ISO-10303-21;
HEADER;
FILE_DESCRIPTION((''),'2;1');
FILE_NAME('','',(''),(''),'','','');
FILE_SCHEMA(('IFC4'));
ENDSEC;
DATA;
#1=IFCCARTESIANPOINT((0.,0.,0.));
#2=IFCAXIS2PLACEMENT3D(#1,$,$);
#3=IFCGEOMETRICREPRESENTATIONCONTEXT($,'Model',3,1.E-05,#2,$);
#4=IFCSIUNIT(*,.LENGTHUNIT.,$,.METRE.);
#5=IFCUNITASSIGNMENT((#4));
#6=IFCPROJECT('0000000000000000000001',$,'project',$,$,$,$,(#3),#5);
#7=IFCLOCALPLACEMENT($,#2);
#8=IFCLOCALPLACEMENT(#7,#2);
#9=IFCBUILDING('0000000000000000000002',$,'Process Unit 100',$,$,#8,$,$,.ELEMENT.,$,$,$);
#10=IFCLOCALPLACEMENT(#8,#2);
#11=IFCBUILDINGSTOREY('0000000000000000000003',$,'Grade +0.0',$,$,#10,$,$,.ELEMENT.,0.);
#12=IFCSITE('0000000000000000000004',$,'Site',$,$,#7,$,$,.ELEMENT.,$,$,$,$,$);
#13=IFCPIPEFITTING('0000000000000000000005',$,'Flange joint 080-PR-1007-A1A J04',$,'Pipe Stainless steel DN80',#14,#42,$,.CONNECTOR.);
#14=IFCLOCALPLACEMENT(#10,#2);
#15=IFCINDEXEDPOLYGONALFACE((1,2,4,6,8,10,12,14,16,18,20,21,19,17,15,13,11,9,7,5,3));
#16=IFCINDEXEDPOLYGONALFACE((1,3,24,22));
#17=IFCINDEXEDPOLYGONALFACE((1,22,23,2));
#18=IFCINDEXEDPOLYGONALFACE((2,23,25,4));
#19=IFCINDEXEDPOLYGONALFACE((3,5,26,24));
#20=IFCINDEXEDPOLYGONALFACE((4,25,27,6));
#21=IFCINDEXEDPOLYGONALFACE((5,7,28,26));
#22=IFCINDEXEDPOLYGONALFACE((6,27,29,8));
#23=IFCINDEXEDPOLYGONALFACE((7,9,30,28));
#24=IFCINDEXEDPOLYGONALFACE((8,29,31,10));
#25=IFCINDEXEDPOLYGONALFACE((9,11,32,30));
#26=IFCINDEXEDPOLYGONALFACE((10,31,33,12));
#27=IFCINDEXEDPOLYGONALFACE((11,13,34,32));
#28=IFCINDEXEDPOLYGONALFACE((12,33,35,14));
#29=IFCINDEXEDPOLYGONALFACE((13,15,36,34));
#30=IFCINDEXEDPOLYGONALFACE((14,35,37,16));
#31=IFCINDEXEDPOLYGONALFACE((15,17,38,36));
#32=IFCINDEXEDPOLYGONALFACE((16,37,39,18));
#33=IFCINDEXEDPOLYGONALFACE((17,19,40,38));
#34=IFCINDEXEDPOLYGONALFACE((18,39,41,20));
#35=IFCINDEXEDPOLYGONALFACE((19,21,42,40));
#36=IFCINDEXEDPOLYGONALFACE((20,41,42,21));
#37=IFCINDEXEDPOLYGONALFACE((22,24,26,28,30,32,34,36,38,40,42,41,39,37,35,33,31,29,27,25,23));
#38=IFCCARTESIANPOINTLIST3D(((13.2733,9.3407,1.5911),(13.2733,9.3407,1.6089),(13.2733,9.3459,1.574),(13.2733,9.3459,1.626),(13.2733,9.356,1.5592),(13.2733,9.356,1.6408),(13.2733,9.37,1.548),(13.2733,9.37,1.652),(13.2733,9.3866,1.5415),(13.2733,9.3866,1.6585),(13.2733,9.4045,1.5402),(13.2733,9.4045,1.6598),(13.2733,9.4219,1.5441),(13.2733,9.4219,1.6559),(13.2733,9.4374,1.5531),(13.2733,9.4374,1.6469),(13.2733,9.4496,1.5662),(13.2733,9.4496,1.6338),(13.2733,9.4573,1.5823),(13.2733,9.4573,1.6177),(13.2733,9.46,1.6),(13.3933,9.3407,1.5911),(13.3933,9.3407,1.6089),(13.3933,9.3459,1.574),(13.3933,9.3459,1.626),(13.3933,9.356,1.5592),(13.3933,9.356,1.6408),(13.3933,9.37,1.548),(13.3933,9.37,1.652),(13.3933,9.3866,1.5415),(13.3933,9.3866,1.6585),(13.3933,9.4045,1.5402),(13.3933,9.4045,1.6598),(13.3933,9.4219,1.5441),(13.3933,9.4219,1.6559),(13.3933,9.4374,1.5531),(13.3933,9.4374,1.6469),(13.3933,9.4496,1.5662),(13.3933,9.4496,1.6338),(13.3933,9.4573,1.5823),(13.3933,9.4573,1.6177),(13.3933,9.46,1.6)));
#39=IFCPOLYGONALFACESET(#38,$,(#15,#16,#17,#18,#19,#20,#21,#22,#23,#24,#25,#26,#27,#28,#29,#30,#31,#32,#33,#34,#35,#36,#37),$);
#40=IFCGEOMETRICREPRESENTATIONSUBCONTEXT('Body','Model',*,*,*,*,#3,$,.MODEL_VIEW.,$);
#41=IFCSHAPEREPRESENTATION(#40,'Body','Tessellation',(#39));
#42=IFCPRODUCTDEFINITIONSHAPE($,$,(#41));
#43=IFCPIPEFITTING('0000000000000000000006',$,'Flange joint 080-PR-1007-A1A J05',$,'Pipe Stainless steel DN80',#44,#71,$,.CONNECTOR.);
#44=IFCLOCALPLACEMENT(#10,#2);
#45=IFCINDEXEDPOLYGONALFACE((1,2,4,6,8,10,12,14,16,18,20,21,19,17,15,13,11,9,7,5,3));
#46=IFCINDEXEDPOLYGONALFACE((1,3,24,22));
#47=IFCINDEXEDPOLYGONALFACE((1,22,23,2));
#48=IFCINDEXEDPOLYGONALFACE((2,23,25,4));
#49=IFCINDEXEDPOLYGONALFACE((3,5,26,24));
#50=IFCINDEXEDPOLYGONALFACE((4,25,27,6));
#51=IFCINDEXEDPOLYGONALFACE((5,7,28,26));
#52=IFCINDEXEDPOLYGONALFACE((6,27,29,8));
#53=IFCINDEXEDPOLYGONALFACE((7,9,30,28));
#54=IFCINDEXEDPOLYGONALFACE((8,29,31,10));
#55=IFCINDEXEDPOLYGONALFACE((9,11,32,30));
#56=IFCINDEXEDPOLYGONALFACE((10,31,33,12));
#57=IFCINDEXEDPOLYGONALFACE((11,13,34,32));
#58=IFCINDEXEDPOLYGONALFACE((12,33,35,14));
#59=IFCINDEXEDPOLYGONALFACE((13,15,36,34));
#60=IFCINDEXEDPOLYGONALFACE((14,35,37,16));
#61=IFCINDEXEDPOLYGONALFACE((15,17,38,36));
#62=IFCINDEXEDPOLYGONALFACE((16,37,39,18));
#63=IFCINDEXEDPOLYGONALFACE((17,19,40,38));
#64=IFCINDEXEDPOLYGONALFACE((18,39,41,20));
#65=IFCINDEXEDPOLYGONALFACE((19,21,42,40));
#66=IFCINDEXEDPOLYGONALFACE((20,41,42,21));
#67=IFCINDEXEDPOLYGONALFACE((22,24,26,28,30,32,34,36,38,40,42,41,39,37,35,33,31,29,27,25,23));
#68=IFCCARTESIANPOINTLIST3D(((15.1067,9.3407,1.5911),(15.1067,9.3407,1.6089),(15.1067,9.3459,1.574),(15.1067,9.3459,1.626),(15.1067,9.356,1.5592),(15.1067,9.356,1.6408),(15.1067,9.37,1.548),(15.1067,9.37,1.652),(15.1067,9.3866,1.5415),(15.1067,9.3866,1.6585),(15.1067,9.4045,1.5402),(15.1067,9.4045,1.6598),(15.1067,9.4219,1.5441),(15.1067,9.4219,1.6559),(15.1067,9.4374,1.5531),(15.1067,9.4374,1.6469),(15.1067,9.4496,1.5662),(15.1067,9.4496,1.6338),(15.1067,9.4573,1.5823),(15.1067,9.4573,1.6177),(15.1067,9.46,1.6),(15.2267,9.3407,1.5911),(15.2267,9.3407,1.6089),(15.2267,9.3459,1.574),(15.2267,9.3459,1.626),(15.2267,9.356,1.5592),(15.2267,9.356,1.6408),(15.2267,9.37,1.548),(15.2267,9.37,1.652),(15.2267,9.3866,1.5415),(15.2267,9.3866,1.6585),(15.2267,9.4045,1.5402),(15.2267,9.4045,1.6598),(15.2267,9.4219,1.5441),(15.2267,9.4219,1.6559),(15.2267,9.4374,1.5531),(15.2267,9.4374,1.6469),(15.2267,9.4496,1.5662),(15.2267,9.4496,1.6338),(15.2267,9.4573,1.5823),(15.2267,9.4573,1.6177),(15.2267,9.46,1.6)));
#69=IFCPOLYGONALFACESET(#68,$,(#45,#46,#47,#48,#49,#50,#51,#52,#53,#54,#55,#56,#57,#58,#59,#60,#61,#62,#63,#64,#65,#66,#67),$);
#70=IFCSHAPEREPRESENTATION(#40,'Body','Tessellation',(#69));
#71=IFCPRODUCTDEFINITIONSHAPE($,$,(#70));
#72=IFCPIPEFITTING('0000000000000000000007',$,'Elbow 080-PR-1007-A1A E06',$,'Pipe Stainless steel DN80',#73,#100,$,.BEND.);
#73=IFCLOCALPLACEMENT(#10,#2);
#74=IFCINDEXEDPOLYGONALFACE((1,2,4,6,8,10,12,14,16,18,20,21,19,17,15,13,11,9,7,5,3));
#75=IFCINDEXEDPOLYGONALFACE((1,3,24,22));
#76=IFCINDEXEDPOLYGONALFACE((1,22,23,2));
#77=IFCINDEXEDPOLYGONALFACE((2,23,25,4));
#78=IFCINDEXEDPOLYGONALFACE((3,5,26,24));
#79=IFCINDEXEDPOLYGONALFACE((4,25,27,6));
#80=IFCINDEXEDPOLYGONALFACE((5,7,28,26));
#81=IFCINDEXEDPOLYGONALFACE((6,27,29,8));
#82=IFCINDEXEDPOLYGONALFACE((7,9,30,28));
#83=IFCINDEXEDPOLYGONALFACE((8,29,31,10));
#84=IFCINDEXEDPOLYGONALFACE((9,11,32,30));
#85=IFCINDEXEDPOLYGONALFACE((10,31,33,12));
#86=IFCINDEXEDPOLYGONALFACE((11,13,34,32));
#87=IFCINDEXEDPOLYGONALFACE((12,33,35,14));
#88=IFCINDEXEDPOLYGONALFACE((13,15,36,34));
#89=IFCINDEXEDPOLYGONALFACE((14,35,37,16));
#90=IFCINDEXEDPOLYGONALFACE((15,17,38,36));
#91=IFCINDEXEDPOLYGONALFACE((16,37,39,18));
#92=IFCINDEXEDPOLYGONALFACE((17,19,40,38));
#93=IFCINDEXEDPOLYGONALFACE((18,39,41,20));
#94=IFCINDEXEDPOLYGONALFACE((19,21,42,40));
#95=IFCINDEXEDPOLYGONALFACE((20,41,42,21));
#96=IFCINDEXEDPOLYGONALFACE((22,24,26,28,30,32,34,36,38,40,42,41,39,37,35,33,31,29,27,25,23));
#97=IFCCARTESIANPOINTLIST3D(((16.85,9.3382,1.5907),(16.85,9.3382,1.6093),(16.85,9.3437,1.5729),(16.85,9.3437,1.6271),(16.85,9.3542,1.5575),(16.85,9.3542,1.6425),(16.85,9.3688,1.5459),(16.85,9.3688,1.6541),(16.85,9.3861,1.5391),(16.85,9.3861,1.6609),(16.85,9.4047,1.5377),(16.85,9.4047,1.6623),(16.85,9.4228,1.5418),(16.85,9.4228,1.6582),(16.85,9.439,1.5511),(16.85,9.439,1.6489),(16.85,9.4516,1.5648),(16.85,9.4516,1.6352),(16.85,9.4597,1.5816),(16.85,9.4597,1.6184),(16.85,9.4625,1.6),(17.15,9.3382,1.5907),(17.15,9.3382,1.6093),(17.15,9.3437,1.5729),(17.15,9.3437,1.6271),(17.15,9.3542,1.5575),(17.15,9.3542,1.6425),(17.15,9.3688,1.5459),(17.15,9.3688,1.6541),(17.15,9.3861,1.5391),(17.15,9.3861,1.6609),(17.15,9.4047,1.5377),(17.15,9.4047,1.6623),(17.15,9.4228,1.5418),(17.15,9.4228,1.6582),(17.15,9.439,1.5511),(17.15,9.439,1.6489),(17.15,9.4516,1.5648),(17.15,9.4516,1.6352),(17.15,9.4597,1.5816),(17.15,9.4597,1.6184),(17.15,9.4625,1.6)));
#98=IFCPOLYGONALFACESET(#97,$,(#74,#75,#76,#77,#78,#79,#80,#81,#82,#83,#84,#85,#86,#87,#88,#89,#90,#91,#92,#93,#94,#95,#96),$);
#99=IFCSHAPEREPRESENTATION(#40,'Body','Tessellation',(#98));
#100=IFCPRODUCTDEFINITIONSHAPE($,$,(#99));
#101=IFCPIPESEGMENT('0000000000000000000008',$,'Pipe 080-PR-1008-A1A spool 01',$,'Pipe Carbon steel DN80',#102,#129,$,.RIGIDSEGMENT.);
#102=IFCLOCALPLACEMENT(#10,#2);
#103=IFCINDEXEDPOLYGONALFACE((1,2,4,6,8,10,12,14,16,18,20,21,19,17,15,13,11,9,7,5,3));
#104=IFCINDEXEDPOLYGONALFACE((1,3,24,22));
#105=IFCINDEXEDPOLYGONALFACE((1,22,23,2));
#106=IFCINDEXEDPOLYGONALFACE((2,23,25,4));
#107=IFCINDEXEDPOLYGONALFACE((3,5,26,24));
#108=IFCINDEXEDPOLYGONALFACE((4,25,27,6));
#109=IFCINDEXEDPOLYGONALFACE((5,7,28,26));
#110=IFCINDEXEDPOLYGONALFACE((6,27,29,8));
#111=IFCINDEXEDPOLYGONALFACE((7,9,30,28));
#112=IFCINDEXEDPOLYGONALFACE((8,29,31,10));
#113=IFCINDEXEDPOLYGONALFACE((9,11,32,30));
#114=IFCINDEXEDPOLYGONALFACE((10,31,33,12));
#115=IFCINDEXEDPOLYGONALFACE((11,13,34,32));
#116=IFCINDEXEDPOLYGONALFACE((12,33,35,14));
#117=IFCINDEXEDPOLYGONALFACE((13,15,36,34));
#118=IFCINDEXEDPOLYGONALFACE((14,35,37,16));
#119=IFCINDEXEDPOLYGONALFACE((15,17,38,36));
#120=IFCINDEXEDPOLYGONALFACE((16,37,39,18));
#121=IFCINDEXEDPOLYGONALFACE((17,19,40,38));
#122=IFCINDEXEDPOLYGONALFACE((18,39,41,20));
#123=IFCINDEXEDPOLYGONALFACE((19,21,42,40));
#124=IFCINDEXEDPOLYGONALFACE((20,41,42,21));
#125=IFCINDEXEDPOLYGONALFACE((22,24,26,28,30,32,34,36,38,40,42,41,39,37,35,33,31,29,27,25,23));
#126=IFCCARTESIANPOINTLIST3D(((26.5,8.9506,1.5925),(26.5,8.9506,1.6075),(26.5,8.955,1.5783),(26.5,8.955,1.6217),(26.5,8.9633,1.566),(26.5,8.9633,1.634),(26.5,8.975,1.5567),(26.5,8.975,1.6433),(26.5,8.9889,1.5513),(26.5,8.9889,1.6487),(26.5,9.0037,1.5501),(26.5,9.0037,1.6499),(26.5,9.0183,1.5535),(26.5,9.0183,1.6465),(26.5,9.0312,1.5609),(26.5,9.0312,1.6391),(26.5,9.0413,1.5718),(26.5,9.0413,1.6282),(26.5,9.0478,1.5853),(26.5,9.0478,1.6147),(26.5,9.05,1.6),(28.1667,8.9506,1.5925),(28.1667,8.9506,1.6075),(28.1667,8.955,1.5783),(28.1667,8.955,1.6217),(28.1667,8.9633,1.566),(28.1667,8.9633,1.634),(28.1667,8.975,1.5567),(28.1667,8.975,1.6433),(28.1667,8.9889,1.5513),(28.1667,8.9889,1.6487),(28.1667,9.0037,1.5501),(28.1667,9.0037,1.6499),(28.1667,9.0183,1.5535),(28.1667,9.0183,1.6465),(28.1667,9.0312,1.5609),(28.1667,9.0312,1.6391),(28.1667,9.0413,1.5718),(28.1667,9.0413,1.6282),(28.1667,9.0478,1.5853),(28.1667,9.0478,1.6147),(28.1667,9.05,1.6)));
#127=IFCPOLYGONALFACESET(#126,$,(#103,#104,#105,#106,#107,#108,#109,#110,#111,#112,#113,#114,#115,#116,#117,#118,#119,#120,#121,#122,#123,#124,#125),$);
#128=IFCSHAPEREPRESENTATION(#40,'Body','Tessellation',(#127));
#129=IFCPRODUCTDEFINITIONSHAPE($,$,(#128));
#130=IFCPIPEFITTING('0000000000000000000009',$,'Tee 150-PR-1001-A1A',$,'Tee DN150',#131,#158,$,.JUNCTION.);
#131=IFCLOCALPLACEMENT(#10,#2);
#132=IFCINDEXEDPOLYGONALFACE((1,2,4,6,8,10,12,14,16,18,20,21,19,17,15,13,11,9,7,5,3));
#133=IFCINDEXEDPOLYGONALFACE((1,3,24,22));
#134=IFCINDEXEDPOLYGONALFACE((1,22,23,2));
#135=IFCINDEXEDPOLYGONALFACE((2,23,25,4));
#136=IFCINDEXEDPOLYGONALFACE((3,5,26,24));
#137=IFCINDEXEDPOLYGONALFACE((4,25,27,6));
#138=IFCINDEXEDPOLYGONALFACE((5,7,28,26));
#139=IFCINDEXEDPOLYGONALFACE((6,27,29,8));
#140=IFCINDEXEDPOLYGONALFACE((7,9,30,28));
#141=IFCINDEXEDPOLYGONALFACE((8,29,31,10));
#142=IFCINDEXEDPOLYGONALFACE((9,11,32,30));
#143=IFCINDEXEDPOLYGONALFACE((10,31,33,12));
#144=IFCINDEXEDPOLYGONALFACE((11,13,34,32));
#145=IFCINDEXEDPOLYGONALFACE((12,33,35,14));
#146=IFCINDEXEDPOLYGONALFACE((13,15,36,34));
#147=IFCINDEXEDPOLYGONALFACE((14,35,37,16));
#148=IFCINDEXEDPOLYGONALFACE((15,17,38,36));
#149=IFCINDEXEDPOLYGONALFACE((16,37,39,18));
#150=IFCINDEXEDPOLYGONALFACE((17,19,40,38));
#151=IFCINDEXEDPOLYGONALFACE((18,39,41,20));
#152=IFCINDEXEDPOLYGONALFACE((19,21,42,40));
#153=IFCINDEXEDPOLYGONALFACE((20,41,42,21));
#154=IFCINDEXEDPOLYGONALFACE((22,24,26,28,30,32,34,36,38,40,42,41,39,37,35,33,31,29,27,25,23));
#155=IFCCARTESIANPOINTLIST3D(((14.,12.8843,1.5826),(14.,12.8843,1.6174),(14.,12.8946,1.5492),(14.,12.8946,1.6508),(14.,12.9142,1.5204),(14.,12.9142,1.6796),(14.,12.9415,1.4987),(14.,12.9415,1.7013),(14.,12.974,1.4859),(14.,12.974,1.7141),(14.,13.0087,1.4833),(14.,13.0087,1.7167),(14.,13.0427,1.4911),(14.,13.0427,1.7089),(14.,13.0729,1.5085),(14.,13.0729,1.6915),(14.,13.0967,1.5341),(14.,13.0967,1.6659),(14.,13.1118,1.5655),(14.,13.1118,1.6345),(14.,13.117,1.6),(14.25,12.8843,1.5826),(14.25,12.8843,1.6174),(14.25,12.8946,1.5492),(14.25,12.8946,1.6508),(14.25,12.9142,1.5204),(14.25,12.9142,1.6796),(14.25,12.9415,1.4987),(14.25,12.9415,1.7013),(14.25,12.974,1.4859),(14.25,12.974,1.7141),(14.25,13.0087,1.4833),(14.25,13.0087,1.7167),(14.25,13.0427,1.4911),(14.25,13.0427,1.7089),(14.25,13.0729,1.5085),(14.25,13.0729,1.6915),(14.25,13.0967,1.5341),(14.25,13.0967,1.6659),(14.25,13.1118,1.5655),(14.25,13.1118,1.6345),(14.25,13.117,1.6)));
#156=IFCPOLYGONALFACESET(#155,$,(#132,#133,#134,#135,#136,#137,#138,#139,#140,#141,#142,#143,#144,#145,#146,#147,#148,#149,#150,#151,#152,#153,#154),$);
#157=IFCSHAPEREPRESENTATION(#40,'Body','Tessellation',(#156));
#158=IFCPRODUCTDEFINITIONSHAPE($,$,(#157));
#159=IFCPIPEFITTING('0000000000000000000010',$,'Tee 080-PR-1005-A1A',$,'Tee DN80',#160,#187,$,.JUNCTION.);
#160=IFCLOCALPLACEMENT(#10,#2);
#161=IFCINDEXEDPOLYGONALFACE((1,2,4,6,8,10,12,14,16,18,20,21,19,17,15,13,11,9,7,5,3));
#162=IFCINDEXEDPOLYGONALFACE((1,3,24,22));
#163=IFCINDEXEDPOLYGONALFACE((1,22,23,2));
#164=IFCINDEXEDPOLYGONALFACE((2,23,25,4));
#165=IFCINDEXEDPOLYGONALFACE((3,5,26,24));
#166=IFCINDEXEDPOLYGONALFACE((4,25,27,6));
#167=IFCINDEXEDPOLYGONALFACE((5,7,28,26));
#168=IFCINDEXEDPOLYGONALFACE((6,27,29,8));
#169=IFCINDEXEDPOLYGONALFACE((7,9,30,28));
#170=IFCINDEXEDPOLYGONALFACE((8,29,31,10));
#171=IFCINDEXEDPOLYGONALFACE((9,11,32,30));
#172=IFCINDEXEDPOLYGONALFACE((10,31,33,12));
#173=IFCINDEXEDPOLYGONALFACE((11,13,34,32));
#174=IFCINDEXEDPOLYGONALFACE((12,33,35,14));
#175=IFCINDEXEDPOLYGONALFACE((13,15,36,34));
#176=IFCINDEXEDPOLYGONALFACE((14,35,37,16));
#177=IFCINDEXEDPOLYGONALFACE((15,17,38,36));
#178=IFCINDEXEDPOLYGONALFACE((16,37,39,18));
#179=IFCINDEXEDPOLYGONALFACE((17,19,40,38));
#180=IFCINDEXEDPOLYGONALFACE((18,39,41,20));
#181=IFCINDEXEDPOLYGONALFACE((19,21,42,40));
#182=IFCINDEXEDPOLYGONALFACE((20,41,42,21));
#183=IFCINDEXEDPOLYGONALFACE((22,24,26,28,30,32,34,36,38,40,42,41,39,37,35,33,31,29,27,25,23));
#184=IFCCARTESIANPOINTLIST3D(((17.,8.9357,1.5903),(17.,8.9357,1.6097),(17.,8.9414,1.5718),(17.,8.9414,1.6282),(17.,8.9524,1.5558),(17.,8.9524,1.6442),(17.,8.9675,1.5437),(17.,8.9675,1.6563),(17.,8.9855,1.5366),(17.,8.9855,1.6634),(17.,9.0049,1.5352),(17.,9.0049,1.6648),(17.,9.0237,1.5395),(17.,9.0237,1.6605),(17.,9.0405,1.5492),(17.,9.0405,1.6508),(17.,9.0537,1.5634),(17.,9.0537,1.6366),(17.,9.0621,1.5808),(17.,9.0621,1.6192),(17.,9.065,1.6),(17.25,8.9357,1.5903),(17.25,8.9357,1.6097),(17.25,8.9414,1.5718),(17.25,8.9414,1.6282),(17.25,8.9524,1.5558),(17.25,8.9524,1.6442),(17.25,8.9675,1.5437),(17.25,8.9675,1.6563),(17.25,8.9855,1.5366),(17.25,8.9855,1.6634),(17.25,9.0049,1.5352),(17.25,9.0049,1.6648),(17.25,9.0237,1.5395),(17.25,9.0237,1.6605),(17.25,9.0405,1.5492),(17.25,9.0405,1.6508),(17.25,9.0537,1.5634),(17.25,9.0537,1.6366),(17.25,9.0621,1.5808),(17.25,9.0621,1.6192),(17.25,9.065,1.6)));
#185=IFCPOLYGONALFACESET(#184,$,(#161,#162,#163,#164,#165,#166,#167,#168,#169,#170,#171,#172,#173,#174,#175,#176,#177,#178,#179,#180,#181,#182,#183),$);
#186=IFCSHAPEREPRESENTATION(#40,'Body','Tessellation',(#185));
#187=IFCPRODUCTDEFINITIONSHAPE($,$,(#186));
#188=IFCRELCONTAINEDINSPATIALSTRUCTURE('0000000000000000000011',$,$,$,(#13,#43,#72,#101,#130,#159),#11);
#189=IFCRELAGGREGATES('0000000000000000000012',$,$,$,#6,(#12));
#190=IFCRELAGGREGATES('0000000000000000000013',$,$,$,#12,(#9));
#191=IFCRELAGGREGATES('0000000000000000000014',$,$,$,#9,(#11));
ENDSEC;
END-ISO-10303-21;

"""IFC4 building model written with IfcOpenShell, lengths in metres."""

from ifc_helpers import new_model, si_unit, frame, origin, place, context, subcontext, project, spatial, circle, extrude, element, save


model = new_model("IFC4")

# Units and contexts
model_context = context("Model", 3, precision=1e-05, world=origin())
body_context = subcontext(model_context, "Body", "Model", "MODEL_VIEW")
ifc_project = project(units=[si_unit("LENGTHUNIT", "METRE")], contexts=[model_context])

# Site, building, storey
site_placement = place(None, origin())
site = spatial("IfcSite", under=ifc_project, at=site_placement, Name="Site", CompositionType="ELEMENT")
building_placement = place(site_placement, origin())
building = spatial("IfcBuilding", under=site, at=building_placement, Name="Process Unit 100", CompositionType="ELEMENT")
storey_placement = place(building_placement, origin())
storey = spatial("IfcBuildingStorey", under=building, at=storey_placement, Name="Grade +0.0", CompositionType="ELEMENT", Elevation=0.0)

# Pipe fittings
for number, where, z_axis, x_axis, name in (
    (1, (13.2733, 9.4, 1.6), (1.0, 0.0, 0.0), (0.0, 1.0, 0.0), "Flange joint 080-PR-1007-A1A J04"),
    (2, (15.1067, 9.4, 1.6), (1.0, 0.0, 0.0), (0.0, 1.0, 0.0), "Flange joint 080-PR-1007-A1A J05"),
):
    element("IfcPipeFitting", number, at=place(storey_placement, frame(where, z_axis=z_axis, x_axis=x_axis)), inside=storey, Name=name, ObjectType="Pipe Stainless steel DN80", PredefinedType="CONNECTOR", context=body_context, shape_type="SweptSolid", body=[
        extrude(circle(Radius=0.06), origin(), (0.0, 0.0, 1.0), 0.12),
    ])
pipe_fitting_1_placement = place(storey_placement, frame((16.85, 9.4, 1.6), z_axis=(1.0, 0.0, 0.0), x_axis=(0.0, 1.0, 0.0)))
element("IfcPipeFitting", 3, at=pipe_fitting_1_placement, inside=storey, Name="Elbow 080-PR-1007-A1A E06", ObjectType="Pipe Stainless steel DN80", PredefinedType="BEND", context=body_context, shape_type="SweptSolid", body=[
    extrude(circle(Radius=0.0625), origin(), (0.0, 0.0, 1.0), 0.3),
])

# Pipe segment
pipe_segment_1_placement = place(storey_placement, frame((26.5, 9.0, 1.6), z_axis=(1.0, 0.0, 0.0), x_axis=(0.0, 1.0, 0.0)))
element("IfcPipeSegment", 4, at=pipe_segment_1_placement, inside=storey, Name="Pipe 080-PR-1008-A1A spool 01", ObjectType="Pipe Carbon steel DN80", PredefinedType="RIGIDSEGMENT", context=body_context, shape_type="SweptSolid", body=[
    extrude(circle(Radius=0.05), origin(), (0.0, 0.0, 1.0), 1.6667),
])

# Pipe fittings
pipe_fitting_2_placement = place(storey_placement, frame((14.0, 13.0, 1.6), z_axis=(1.0, 0.0, 0.0), x_axis=(0.0, 1.0, 0.0)))
element("IfcPipeFitting", 5, at=pipe_fitting_2_placement, inside=storey, Name="Tee 150-PR-1001-A1A", ObjectType="Tee DN150", PredefinedType="JUNCTION", context=body_context, shape_type="SweptSolid", body=[
    extrude(circle(Radius=0.117), origin(), (0.0, 0.0, 1.0), 0.25),
])
pipe_fitting_3_placement = place(storey_placement, frame((17.0, 9.0, 1.6), z_axis=(1.0, 0.0, 0.0), x_axis=(0.0, 1.0, 0.0)))
element("IfcPipeFitting", 6, at=pipe_fitting_3_placement, inside=storey, Name="Tee 080-PR-1005-A1A", ObjectType="Tee DN80", PredefinedType="JUNCTION", context=body_context, shape_type="SweptSolid", body=[
    extrude(circle(Radius=0.065), origin(), (0.0, 0.0, 1.0), 0.25),
])

save(model, "model.ifc")
